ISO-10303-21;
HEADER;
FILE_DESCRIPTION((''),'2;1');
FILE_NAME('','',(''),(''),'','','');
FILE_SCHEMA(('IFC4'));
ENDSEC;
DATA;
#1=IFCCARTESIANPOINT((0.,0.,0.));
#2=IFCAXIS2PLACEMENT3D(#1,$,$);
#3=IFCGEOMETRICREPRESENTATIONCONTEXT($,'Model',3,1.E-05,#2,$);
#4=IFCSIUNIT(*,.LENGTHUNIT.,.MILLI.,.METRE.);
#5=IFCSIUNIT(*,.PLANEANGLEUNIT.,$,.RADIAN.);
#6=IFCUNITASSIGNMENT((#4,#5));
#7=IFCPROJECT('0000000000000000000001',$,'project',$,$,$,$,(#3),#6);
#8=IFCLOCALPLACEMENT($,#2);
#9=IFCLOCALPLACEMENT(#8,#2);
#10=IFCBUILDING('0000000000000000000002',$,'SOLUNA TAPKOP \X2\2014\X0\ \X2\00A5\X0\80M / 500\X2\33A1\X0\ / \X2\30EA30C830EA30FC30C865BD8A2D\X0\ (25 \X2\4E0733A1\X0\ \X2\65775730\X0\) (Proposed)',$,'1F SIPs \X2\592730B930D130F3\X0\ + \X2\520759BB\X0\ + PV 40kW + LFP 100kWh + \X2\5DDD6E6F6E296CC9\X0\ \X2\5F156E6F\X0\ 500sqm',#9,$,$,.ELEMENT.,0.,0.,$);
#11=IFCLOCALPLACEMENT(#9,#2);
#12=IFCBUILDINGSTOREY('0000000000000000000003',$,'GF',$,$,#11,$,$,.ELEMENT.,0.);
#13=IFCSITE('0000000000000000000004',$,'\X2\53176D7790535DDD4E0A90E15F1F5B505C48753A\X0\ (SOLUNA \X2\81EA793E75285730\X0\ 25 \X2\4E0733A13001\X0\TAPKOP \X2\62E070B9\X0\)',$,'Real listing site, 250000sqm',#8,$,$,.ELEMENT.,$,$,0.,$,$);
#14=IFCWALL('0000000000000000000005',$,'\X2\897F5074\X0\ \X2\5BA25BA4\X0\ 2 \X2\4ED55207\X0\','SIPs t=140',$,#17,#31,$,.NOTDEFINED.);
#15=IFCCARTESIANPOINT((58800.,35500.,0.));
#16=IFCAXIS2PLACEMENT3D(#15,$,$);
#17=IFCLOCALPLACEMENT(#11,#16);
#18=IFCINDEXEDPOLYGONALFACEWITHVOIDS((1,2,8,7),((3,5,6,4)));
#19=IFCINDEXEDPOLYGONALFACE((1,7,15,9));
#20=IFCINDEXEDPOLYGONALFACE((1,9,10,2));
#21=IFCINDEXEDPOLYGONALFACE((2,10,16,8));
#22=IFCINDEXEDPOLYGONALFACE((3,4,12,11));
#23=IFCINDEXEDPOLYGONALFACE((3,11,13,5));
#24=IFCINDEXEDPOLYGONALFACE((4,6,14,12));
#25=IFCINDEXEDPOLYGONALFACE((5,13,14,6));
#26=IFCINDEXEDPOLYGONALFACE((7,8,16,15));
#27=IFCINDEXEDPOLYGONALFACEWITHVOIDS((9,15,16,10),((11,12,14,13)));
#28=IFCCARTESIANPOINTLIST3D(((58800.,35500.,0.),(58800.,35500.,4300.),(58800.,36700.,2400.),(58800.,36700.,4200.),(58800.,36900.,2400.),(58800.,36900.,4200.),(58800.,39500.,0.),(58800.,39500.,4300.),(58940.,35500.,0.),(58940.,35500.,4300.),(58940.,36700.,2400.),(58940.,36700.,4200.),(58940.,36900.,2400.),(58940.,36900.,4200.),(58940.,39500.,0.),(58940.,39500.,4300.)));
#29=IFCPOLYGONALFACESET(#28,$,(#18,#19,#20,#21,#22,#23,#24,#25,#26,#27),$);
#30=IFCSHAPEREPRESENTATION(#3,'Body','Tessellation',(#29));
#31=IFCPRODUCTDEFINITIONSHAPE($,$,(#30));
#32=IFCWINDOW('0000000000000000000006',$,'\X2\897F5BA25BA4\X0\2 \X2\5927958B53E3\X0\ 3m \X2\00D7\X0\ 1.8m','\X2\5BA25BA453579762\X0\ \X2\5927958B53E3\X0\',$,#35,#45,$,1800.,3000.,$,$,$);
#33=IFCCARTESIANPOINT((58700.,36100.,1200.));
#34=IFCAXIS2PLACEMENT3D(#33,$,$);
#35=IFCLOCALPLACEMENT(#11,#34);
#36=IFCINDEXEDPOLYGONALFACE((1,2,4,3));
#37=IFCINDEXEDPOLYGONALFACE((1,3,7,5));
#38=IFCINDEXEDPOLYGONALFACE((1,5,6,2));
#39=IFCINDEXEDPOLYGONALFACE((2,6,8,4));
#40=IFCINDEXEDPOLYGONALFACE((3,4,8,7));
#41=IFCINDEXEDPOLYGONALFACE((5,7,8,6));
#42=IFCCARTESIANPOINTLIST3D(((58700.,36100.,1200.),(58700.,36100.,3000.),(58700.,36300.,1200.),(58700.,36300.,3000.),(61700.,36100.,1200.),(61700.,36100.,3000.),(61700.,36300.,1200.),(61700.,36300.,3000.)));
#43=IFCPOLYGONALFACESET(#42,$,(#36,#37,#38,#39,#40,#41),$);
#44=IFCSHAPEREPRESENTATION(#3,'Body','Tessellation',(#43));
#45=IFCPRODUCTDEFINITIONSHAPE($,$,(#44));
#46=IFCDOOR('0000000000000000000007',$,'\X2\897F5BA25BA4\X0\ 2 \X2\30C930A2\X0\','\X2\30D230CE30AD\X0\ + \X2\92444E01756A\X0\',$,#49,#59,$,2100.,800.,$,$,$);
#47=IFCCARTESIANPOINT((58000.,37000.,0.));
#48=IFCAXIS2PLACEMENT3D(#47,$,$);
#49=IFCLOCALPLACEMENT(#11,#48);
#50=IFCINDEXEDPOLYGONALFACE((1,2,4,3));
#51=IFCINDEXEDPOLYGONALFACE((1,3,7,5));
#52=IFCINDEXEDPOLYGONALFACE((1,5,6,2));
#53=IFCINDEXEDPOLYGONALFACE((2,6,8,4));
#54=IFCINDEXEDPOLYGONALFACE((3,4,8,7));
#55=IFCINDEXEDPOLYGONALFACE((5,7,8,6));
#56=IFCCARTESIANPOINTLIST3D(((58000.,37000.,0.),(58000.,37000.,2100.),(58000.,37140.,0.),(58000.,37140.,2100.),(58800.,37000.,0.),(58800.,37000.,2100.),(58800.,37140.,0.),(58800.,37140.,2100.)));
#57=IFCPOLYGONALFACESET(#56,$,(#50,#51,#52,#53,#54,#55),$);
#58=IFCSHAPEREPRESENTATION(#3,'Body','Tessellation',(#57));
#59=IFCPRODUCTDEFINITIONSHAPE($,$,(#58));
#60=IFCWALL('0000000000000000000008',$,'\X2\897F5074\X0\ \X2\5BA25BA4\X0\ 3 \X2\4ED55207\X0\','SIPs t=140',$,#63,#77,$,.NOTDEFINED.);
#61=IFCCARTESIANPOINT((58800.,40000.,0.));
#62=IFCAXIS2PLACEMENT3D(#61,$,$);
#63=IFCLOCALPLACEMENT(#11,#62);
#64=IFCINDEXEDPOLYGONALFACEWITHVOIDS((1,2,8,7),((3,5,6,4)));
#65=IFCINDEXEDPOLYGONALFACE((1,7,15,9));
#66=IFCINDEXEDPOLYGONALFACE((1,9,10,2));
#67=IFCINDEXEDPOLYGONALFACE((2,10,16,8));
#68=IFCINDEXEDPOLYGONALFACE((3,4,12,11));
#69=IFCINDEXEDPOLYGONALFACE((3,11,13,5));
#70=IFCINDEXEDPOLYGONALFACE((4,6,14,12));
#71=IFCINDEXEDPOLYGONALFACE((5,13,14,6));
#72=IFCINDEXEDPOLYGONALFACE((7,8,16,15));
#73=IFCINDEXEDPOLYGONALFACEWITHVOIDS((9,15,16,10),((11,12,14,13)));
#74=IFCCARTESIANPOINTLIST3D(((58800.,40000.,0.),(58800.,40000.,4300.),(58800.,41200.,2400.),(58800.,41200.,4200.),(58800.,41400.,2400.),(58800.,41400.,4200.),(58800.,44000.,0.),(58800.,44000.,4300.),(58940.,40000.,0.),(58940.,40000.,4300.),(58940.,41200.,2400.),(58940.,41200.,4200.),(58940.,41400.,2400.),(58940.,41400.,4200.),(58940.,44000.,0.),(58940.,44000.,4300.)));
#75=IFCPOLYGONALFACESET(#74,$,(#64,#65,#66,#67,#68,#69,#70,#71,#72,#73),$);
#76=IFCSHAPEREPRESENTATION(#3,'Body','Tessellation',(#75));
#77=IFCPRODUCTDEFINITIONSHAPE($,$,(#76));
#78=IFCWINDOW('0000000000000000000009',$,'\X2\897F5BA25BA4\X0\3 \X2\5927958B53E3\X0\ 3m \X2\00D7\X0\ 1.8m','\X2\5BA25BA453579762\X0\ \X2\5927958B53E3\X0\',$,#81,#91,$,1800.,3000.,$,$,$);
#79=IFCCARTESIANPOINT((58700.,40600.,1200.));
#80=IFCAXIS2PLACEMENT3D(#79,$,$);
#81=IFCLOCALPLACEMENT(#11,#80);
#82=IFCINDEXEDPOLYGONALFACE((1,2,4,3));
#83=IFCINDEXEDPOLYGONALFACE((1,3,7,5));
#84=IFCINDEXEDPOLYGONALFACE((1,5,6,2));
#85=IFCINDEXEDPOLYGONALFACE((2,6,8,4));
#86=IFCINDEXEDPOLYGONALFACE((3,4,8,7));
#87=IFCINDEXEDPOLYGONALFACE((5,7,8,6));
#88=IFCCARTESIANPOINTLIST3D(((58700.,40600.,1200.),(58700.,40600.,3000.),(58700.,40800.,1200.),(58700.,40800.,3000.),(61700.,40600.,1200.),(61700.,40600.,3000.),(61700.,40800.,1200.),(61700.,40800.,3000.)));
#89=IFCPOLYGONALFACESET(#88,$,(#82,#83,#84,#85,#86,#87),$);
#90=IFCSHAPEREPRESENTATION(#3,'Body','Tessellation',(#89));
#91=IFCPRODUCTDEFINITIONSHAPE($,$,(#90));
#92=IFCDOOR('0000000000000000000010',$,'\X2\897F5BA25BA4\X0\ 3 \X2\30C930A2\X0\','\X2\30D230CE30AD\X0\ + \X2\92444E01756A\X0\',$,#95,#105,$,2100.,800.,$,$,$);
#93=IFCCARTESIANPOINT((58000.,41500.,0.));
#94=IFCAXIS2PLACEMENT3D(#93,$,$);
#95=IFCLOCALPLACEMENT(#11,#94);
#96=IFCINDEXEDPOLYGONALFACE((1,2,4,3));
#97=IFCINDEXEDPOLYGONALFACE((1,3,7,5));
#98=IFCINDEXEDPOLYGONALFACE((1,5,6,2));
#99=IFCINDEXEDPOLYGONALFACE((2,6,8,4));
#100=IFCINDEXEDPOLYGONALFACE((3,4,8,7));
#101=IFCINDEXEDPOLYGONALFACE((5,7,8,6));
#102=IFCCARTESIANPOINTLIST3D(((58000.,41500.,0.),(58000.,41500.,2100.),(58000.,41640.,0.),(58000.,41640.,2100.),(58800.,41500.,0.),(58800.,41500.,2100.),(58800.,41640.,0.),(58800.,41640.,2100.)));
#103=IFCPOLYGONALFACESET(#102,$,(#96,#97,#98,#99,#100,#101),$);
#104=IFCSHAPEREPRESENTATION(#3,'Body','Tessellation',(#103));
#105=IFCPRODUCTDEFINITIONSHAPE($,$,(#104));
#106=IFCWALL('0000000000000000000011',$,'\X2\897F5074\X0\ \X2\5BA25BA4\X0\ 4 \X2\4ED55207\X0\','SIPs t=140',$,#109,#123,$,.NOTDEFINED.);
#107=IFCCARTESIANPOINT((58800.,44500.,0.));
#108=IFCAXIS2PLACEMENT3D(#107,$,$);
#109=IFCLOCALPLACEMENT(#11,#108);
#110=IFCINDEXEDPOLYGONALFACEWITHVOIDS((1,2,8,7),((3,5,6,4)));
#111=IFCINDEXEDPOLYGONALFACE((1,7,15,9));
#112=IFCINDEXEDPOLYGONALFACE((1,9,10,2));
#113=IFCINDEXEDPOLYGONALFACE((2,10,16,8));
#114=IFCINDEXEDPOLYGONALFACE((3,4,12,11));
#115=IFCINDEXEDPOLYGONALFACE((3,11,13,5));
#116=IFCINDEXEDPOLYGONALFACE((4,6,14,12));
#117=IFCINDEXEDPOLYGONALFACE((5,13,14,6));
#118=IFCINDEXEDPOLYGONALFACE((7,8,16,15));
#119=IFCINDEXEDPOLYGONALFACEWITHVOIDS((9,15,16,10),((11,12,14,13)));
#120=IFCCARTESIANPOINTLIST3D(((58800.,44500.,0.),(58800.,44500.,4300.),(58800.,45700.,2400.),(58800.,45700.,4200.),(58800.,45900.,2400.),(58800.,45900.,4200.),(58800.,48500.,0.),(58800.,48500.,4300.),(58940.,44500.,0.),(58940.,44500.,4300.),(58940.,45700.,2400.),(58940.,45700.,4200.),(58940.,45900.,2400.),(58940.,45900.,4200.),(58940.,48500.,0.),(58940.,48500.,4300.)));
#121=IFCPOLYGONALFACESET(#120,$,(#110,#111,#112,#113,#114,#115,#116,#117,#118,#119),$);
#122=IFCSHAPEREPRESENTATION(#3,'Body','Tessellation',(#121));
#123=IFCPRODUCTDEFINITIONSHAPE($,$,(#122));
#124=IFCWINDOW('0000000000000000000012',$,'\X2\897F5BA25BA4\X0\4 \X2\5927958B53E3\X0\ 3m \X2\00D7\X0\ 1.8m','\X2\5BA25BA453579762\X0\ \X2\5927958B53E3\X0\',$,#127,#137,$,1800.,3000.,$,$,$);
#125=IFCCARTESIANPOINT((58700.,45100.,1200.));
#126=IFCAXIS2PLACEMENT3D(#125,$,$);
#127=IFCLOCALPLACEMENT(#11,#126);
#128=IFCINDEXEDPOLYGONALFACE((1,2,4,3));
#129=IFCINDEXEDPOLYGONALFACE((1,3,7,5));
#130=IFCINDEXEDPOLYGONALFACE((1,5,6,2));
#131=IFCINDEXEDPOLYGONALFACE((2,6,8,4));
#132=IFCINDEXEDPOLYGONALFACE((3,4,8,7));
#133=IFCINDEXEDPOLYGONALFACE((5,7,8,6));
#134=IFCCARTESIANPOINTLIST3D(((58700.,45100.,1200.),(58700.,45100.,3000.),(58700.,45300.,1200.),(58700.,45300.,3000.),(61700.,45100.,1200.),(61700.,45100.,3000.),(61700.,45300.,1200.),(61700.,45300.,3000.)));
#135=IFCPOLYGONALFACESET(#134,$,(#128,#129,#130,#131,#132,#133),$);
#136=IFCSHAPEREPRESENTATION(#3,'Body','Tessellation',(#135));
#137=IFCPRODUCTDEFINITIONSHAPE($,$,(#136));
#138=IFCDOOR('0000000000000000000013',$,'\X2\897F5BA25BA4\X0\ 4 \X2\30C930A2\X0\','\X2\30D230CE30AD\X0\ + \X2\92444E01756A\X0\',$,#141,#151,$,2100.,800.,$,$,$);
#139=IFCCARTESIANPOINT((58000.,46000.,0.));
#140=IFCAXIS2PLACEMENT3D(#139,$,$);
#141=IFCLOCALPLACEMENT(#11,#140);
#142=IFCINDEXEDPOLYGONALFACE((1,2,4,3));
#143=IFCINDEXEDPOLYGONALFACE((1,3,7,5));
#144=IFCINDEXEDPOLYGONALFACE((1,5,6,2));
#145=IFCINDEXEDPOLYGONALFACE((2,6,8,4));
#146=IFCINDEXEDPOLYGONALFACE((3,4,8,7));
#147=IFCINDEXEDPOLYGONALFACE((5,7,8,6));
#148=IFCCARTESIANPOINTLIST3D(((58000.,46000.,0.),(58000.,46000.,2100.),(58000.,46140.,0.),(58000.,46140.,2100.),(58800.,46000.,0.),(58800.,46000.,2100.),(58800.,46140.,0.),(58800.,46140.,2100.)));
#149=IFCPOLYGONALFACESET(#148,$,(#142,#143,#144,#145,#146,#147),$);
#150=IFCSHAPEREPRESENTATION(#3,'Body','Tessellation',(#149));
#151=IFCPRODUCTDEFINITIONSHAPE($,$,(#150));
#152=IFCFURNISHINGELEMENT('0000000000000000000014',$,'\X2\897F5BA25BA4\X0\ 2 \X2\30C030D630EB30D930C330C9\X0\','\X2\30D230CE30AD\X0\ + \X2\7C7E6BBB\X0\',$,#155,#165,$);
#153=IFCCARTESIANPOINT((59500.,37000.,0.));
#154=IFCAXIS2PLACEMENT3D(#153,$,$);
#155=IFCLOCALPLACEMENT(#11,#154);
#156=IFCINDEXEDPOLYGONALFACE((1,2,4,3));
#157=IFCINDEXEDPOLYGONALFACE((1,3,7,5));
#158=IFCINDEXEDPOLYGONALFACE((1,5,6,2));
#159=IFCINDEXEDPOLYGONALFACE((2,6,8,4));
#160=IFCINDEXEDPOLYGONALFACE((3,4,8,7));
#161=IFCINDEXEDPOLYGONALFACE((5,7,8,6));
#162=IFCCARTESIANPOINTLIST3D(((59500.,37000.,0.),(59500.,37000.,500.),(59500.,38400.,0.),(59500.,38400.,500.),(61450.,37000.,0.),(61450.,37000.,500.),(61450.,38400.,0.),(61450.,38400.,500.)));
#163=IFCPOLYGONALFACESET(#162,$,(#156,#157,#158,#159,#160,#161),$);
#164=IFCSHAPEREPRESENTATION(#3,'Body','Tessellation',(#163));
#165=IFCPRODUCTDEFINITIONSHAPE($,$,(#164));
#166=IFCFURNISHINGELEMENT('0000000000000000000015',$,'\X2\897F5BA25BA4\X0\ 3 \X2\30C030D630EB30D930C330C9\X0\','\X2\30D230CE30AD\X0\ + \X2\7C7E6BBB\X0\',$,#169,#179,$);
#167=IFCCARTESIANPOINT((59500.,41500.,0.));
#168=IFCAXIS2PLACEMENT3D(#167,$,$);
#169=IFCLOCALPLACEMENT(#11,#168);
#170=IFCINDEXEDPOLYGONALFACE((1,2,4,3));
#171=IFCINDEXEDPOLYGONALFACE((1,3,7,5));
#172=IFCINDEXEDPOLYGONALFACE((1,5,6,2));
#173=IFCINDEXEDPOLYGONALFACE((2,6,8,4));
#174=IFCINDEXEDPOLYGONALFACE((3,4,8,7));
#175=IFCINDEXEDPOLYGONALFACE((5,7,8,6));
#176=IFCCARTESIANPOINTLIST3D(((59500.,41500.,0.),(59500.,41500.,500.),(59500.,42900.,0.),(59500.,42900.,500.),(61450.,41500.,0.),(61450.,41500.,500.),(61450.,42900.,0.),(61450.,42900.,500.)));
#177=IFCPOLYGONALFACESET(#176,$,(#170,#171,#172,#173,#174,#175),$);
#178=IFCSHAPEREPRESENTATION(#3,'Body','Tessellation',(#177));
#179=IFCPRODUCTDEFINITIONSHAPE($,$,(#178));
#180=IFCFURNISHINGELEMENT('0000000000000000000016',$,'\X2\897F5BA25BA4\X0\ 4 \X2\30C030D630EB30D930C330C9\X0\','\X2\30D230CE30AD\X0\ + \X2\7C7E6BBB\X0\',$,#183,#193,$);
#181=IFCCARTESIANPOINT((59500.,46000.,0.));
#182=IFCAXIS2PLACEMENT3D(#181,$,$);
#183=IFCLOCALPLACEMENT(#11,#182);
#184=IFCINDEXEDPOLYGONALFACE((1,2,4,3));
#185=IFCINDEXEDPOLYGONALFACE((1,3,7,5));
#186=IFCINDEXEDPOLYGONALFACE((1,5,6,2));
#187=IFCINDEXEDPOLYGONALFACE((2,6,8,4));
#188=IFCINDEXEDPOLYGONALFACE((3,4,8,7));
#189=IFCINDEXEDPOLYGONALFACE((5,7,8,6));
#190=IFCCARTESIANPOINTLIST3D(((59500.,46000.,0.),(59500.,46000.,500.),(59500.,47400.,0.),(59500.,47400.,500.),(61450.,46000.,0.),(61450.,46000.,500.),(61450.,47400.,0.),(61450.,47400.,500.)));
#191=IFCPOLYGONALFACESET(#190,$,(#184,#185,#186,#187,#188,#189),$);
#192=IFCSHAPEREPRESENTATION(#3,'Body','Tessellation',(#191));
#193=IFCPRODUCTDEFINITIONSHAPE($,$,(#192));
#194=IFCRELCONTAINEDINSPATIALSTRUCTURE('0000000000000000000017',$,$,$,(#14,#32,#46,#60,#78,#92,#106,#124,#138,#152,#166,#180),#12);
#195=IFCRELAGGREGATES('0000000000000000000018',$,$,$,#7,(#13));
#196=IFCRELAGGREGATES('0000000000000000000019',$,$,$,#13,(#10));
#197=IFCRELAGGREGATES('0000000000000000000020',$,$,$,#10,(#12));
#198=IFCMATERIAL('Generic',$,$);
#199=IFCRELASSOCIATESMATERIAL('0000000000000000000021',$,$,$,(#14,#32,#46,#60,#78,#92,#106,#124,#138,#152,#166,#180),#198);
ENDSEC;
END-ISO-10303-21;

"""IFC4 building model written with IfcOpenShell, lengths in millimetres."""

from ifc_helpers import new_model, si_unit, frame, frame_2d, origin, place, context, project, spatial, rectangle, extrude, material, element, fill, save


model = new_model("IFC4")

# Units and contexts
model_context = context("Model", 3, precision=1e-05, world=origin())
ifc_project = project(units=[si_unit("LENGTHUNIT", "METRE", prefix="MILLI"), si_unit("PLANEANGLEUNIT", "RADIAN")], contexts=[model_context])

# Site, building, storey
site_placement = place(None, origin())
site = spatial("IfcSite", under=ifc_project, at=site_placement, Name="北海道川上郡弟子屈町 (SOLUNA 自社用地 25 万㎡、TAPKOP 拠点)", ObjectType="Real listing site, 250000sqm", CompositionType="ELEMENT", RefElevation=0.0)
building_placement = place(site_placement, origin())
building = spatial("IfcBuilding", under=site, at=building_placement, Name="SOLUNA TAPKOP — ¥80M / 500㎡ / リトリート施設 (25 万㎡ 敷地) (Proposed)", ObjectType="1F SIPs 大スパン + 切妻 + PV 40kW + LFP 100kWh + 川湯温泉 引湯 500sqm", CompositionType="ELEMENT", ElevationOfRefHeight=0.0, ElevationOfTerrain=0.0)
storey_placement = place(building_placement, origin())
storey = spatial("IfcBuildingStorey", under=building, at=storey_placement, Name="GF", CompositionType="ELEMENT", Elevation=0.0)

# Wall, opening, window
ifc_material = material(Name="Generic")
wall_1_placement = place(storey_placement, frame((58800.0, 35500.0, 0.0)))
wall_1 = element("IfcWall", 1, at=wall_1_placement, inside=storey, material=ifc_material, Name="西側 客室 2 仕切", Description="SIPs t=140", PredefinedType="NOTDEFINED", context=model_context, shape_type="SweptSolid", body=[
    extrude(rectangle(XDim=140.0, YDim=4000.0, at=frame_2d((70.0, 2000.0))), frame((58800.0, 35500.0, 0.0)), (0.0, 0.0, 1.0), 4300.0),
])
opening_1_placement = place(storey_placement, frame((58700.0, 36100.0, 1200.0)))
opening_1 = element("IfcOpeningElement", 2, at=opening_1_placement, cuts=wall_1, PredefinedType="NOTDEFINED", context=model_context, shape_type="SweptSolid", body=[
    extrude(rectangle(XDim=3000.0, YDim=200.0, at=frame_2d((1500.0, 100.0))), frame((58700.0, 36100.0, 1200.0)), (0.0, 0.0, 1.0), 1800.0),
])
window_1_placement = place(storey_placement, frame((58700.0, 36100.0, 1200.0)))
window_1 = element("IfcWindow", 3, at=window_1_placement, inside=storey, material=ifc_material, Name="西客室2 大開口 3m × 1.8m", Description="客室南面 大開口", OverallHeight=1800.0, OverallWidth=3000.0, context=model_context, shape_type="SweptSolid", body=[
    extrude(rectangle(XDim=3000.0, YDim=200.0, at=frame_2d((1500.0, 100.0))), frame((58700.0, 36100.0, 1200.0)), (0.0, 0.0, 1.0), 1800.0),
])
fill(opening_1, window_1)

# Door
door_1_placement = place(storey_placement, frame((58000.0, 37000.0, 0.0)))
element("IfcDoor", 4, at=door_1_placement, inside=storey, material=ifc_material, Name="西客室 2 ドア", Description="ヒノキ + 鉄丁番", OverallHeight=2100.0, OverallWidth=800.0, context=model_context, shape_type="SweptSolid", body=[
    extrude(rectangle(XDim=800.0, YDim=140.0, at=frame_2d((400.0, 70.0))), frame((58000.0, 37000.0, 0.0)), (0.0, 0.0, 1.0), 2100.0),
])

# Wall, opening, window
wall_2_placement = place(storey_placement, frame((58800.0, 40000.0, 0.0)))
wall_2 = element("IfcWall", 5, at=wall_2_placement, inside=storey, material=ifc_material, Name="西側 客室 3 仕切", Description="SIPs t=140", PredefinedType="NOTDEFINED", context=model_context, shape_type="SweptSolid", body=[
    extrude(rectangle(XDim=140.0, YDim=4000.0, at=frame_2d((70.0, 2000.0))), frame((58800.0, 40000.0, 0.0)), (0.0, 0.0, 1.0), 4300.0),
])
opening_2_placement = place(storey_placement, frame((58700.0, 40600.0, 1200.0)))
opening_2 = element("IfcOpeningElement", 6, at=opening_2_placement, cuts=wall_2, PredefinedType="NOTDEFINED", context=model_context, shape_type="SweptSolid", body=[
    extrude(rectangle(XDim=3000.0, YDim=200.0, at=frame_2d((1500.0, 100.0))), frame((58700.0, 40600.0, 1200.0)), (0.0, 0.0, 1.0), 1800.0),
])
window_2_placement = place(storey_placement, frame((58700.0, 40600.0, 1200.0)))
window_2 = element("IfcWindow", 7, at=window_2_placement, inside=storey, material=ifc_material, Name="西客室3 大開口 3m × 1.8m", Description="客室南面 大開口", OverallHeight=1800.0, OverallWidth=3000.0, context=model_context, shape_type="SweptSolid", body=[
    extrude(rectangle(XDim=3000.0, YDim=200.0, at=frame_2d((1500.0, 100.0))), frame((58700.0, 40600.0, 1200.0)), (0.0, 0.0, 1.0), 1800.0),
])
fill(opening_2, window_2)

# Door
door_2_placement = place(storey_placement, frame((58000.0, 41500.0, 0.0)))
element("IfcDoor", 8, at=door_2_placement, inside=storey, material=ifc_material, Name="西客室 3 ドア", Description="ヒノキ + 鉄丁番", OverallHeight=2100.0, OverallWidth=800.0, context=model_context, shape_type="SweptSolid", body=[
    extrude(rectangle(XDim=800.0, YDim=140.0, at=frame_2d((400.0, 70.0))), frame((58000.0, 41500.0, 0.0)), (0.0, 0.0, 1.0), 2100.0),
])

# Wall, opening, window
wall_3_placement = place(storey_placement, frame((58800.0, 44500.0, 0.0)))
wall_3 = element("IfcWall", 9, at=wall_3_placement, inside=storey, material=ifc_material, Name="西側 客室 4 仕切", Description="SIPs t=140", PredefinedType="NOTDEFINED", context=model_context, shape_type="SweptSolid", body=[
    extrude(rectangle(XDim=140.0, YDim=4000.0, at=frame_2d((70.0, 2000.0))), frame((58800.0, 44500.0, 0.0)), (0.0, 0.0, 1.0), 4300.0),
])
opening_3_placement = place(storey_placement, frame((58700.0, 45100.0, 1200.0)))
opening_3 = element("IfcOpeningElement", 10, at=opening_3_placement, cuts=wall_3, PredefinedType="NOTDEFINED", context=model_context, shape_type="SweptSolid", body=[
    extrude(rectangle(XDim=3000.0, YDim=200.0, at=frame_2d((1500.0, 100.0))), frame((58700.0, 45100.0, 1200.0)), (0.0, 0.0, 1.0), 1800.0),
])
window_3_placement = place(storey_placement, frame((58700.0, 45100.0, 1200.0)))
window_3 = element("IfcWindow", 11, at=window_3_placement, inside=storey, material=ifc_material, Name="西客室4 大開口 3m × 1.8m", Description="客室南面 大開口", OverallHeight=1800.0, OverallWidth=3000.0, context=model_context, shape_type="SweptSolid", body=[
    extrude(rectangle(XDim=3000.0, YDim=200.0, at=frame_2d((1500.0, 100.0))), frame((58700.0, 45100.0, 1200.0)), (0.0, 0.0, 1.0), 1800.0),
])
fill(opening_3, window_3)

# Door
door_3_placement = place(storey_placement, frame((58000.0, 46000.0, 0.0)))
element("IfcDoor", 12, at=door_3_placement, inside=storey, material=ifc_material, Name="西客室 4 ドア", Description="ヒノキ + 鉄丁番", OverallHeight=2100.0, OverallWidth=800.0, context=model_context, shape_type="SweptSolid", body=[
    extrude(rectangle(XDim=800.0, YDim=140.0, at=frame_2d((400.0, 70.0))), frame((58000.0, 46000.0, 0.0)), (0.0, 0.0, 1.0), 2100.0),
])

# Furnishing elements
furnishing_1_placement = place(storey_placement, frame((59500.0, 37000.0, 0.0)))
element("IfcFurnishingElement", 13, at=furnishing_1_placement, inside=storey, material=ifc_material, Name="西客室 2 ダブルベッド", Description="ヒノキ + 籾殻", context=model_context, shape_type="SweptSolid", body=[
    extrude(rectangle(XDim=1950.0, YDim=1400.0, at=frame_2d((975.0, 700.0))), frame((59500.0, 37000.0, 0.0)), (0.0, 0.0, 1.0), 500.0),
])
furnishing_2_placement = place(storey_placement, frame((59500.0, 41500.0, 0.0)))
element("IfcFurnishingElement", 14, at=furnishing_2_placement, inside=storey, material=ifc_material, Name="西客室 3 ダブルベッド", Description="ヒノキ + 籾殻", context=model_context, shape_type="SweptSolid", body=[
    extrude(rectangle(XDim=1950.0, YDim=1400.0, at=frame_2d((975.0, 700.0))), frame((59500.0, 41500.0, 0.0)), (0.0, 0.0, 1.0), 500.0),
])
furnishing_3_placement = place(storey_placement, frame((59500.0, 46000.0, 0.0)))
element("IfcFurnishingElement", 15, at=furnishing_3_placement, inside=storey, material=ifc_material, Name="西客室 4 ダブルベッド", Description="ヒノキ + 籾殻", context=model_context, shape_type="SweptSolid", body=[
    extrude(rectangle(XDim=1950.0, YDim=1400.0, at=frame_2d((975.0, 700.0))), frame((59500.0, 46000.0, 0.0)), (0.0, 0.0, 1.0), 500.0),
])

save(model, "model.ifc")
